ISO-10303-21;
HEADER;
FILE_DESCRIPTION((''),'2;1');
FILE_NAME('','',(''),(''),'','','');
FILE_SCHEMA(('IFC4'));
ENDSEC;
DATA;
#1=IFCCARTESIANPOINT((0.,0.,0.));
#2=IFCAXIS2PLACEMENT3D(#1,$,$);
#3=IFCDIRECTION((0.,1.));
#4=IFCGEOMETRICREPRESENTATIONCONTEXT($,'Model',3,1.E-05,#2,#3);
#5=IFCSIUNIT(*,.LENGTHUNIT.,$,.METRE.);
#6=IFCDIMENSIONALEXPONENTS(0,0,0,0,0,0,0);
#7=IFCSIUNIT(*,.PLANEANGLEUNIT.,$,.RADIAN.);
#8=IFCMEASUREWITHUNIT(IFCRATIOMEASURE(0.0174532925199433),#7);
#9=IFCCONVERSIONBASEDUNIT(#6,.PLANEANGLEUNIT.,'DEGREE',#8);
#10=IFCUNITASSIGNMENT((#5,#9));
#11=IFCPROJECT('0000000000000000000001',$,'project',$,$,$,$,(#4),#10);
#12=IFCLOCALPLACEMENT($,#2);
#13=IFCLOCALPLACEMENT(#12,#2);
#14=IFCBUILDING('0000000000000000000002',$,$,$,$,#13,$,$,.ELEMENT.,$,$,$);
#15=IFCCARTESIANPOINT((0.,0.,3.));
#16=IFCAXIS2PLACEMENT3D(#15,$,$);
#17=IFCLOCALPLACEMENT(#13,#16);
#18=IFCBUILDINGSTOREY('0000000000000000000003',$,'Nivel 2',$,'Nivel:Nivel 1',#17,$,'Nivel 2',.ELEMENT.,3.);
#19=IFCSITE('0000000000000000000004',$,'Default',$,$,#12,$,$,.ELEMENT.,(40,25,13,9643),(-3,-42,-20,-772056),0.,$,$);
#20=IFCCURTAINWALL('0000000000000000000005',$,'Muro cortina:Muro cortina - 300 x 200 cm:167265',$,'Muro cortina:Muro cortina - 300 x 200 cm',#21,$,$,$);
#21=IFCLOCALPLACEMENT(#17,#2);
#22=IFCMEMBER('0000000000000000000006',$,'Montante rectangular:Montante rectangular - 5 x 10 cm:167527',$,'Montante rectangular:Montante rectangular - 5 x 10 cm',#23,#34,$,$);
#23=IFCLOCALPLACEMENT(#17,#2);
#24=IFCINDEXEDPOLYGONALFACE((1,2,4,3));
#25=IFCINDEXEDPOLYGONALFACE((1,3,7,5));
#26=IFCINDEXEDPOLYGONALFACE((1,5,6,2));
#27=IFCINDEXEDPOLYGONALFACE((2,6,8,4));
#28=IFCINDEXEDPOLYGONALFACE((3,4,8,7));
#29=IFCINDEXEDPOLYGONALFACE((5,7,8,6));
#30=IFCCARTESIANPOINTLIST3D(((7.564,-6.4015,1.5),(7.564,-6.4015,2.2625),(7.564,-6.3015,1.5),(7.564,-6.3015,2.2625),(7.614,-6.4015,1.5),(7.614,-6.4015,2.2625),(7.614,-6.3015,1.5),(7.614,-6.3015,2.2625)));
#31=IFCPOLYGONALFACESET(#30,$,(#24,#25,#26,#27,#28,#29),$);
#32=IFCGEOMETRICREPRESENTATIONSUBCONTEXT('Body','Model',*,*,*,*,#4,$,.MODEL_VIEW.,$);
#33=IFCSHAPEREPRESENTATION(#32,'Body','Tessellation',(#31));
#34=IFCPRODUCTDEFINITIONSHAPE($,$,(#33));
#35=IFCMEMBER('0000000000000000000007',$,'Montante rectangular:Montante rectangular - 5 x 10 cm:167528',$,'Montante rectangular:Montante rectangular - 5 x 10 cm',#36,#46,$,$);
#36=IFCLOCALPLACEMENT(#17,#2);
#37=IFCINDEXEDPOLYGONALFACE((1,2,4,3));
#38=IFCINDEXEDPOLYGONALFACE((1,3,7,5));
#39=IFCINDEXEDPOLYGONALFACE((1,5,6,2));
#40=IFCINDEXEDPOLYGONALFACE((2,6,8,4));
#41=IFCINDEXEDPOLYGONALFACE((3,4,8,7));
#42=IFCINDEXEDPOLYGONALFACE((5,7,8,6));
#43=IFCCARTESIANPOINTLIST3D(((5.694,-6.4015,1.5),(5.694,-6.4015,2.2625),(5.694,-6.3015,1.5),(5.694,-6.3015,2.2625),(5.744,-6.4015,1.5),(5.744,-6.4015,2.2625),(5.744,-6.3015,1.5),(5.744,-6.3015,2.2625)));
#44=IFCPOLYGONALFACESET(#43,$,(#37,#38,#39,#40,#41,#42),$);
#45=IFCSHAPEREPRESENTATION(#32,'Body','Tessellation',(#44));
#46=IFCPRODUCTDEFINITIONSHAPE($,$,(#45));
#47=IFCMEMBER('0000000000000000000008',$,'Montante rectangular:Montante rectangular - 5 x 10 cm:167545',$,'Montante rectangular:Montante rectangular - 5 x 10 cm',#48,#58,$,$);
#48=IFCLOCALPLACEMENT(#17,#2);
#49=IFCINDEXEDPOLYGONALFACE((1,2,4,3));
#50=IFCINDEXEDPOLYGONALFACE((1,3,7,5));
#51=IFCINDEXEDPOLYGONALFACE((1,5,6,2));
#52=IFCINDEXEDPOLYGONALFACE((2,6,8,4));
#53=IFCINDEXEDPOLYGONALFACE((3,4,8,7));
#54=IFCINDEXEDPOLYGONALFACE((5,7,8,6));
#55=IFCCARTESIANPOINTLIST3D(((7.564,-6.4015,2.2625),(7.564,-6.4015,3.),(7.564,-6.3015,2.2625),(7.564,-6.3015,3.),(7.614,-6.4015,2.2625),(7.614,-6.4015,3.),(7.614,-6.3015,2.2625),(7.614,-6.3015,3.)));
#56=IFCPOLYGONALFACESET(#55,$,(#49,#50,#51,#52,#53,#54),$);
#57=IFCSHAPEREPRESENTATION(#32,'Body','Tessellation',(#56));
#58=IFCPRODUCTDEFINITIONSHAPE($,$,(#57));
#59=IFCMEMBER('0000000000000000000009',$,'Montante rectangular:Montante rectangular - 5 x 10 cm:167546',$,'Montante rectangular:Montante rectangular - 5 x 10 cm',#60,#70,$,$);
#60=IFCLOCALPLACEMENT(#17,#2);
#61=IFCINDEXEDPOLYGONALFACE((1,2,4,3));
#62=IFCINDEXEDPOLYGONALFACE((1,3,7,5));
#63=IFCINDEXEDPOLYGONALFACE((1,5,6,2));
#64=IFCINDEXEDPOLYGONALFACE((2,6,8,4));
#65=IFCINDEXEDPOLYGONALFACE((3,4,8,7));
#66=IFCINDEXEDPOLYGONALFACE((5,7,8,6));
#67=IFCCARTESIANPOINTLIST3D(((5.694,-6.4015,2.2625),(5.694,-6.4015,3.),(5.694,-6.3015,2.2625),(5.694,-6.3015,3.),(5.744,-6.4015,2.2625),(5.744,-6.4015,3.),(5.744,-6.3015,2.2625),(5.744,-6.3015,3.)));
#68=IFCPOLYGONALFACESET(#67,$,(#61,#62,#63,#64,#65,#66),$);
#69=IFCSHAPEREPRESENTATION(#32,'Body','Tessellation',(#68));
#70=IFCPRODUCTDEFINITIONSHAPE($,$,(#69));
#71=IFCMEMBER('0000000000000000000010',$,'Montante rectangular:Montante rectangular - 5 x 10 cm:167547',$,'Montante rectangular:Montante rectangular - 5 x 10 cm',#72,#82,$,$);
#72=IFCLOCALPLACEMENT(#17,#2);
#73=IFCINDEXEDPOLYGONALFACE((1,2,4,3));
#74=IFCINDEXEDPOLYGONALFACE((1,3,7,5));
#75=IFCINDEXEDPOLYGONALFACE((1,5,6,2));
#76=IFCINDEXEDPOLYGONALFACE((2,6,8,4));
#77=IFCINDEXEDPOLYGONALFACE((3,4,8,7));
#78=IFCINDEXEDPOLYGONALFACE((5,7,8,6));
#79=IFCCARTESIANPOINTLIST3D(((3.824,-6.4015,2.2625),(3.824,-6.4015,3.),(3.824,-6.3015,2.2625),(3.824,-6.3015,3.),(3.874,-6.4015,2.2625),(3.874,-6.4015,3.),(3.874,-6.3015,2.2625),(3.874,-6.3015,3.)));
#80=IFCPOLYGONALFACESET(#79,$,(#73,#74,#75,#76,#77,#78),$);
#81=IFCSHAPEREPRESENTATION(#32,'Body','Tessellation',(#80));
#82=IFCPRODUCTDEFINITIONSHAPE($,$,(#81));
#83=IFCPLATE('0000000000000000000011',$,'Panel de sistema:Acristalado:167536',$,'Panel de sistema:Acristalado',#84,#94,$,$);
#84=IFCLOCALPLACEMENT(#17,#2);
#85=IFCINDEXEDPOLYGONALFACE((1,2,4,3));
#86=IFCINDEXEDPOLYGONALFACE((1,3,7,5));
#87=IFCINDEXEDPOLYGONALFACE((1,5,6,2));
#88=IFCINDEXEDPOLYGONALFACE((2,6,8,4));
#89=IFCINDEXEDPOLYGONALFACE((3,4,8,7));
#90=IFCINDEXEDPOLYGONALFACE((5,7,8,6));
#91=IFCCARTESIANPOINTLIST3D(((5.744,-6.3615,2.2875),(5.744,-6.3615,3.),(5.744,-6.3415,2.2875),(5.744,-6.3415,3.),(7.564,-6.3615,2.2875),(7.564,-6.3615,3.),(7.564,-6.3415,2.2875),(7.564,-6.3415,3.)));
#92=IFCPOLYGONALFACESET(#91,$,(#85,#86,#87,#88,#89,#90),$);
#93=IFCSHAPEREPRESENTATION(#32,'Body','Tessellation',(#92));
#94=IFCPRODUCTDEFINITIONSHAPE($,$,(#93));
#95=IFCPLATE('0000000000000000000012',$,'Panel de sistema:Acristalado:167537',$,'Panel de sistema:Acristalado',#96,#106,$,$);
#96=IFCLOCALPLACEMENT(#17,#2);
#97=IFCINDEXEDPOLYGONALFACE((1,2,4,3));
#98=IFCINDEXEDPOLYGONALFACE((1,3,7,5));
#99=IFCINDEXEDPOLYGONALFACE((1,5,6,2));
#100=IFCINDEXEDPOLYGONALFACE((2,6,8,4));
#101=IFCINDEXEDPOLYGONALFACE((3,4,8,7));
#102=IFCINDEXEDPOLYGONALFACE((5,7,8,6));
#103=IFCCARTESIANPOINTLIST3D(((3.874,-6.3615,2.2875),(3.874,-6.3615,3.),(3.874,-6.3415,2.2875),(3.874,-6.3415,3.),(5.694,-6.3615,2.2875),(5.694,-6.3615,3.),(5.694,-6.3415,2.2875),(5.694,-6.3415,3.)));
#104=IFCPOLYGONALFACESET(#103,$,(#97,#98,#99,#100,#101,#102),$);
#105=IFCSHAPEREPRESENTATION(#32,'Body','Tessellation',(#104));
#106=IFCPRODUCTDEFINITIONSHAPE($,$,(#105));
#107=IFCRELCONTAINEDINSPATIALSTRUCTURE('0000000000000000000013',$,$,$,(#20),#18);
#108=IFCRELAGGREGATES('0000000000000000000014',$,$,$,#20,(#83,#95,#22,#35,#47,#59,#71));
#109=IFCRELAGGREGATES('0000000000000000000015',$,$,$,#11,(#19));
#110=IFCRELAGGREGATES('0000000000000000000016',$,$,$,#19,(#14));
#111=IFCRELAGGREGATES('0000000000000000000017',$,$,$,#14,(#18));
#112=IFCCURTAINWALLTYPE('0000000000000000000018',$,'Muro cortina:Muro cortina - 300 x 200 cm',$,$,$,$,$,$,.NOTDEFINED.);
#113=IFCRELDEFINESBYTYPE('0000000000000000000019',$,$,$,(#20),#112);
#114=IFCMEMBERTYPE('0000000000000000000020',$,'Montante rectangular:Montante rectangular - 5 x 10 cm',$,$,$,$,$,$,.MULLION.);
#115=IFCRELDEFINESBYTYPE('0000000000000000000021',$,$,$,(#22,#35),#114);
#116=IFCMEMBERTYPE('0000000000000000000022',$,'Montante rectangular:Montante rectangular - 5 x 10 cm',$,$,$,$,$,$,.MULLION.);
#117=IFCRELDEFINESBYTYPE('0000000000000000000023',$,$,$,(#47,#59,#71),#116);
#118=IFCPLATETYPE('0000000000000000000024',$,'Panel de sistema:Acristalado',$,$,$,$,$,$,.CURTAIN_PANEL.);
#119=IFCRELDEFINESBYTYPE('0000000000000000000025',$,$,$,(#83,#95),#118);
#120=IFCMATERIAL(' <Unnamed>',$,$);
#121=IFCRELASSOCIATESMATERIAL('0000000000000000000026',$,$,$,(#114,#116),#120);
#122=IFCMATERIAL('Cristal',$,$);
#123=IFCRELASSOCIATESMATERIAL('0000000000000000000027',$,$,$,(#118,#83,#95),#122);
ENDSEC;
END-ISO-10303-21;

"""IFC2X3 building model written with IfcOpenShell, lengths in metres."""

from ifc_helpers import new_model, entity, si_unit, converted_unit, direction, frame, origin, origin_2d_with_axis, place, context, subcontext, project, spatial, rectangle, extrude, source, transform, mapped, material, type_object, type_shapes, element, aggregate, save


model = new_model("IFC2X3")

# Units and contexts
model_context = context("Model", 3, precision=1e-05, world=origin(), true_north=direction((0.0, 1.0)))
body_context = subcontext(model_context, "Body", "Model", "MODEL_VIEW")
ifc_project = project(units=[si_unit("LENGTHUNIT", "METRE"), converted_unit("PLANEANGLEUNIT", "DEGREE", entity("IfcRatioMeasure", 0.0174532925199433), si_unit("PLANEANGLEUNIT", "RADIAN"), dimensions=[0, 0, 0, 0, 0, 0, 0])], contexts=[model_context])

# Site, building, storey
site_placement = place(None, origin())
site = spatial("IfcSite", under=ifc_project, at=site_placement, Name="Default", CompositionType="ELEMENT", RefLatitude=(40, 25, 13, 9643), RefLongitude=(-3, -42, -20, -772056), RefElevation=0.0)
building_placement = place(site_placement, origin())
building = spatial("IfcBuilding", under=site, at=building_placement, CompositionType="ELEMENT")
storey_placement = place(building_placement, frame((0.0, 0.0, 3.0)))
storey = spatial("IfcBuildingStorey", under=building, at=storey_placement, Name="Nivel 2", ObjectType="Nivel:Nivel 1", LongName="Nivel 2", CompositionType="ELEMENT", Elevation=3.0)

# Curtain wall, members, plates
curtain_wall_type = type_object("IfcCurtainWallType", Name="Muro cortina:Muro cortina - 300 x 200 cm", PredefinedType="NOTDEFINED")
curtain_wall_placement = place(storey_placement, frame((0.0, 0.0, -3.0)))
curtain_wall = element("IfcCurtainWall", 1, at=curtain_wall_placement, inside=storey, type_object=curtain_wall_type, Name="Muro cortina:Muro cortina - 300 x 200 cm:167265", ObjectType="Muro cortina:Muro cortina - 300 x 200 cm")
ifc_material_1 = material(Name=" <Unnamed>")
member_type_1 = type_object("IfcMemberType", Name="Montante rectangular:Montante rectangular - 5 x 10 cm", PredefinedType="MULLION", material=ifc_material_1)
shared_shape_1 = source(origin(), body_context, "Body", "SweptSolid", [
    extrude(rectangle(XDim=0.1, YDim=0.05, at=origin_2d_with_axis()), frame((0.0, 0.0, -0.7625), z_axis=(0.0, 0.0, 1.0), x_axis=(0.0, -1.0, 0.0)), (0.0, 0.0, 1.0), 0.7625),
])
type_shapes(member_type_1, [shared_shape_1])
member_1_placement = place(storey_placement, frame((7.589, -6.3515, 1.5), z_axis=(0.0, 0.0, -1.0), x_axis=(-1.0, 0.0, 0.0)))
member_1 = element("IfcMember", 2, at=member_1_placement, type_object=member_type_1, Name="Montante rectangular:Montante rectangular - 5 x 10 cm:167527", ObjectType="Montante rectangular:Montante rectangular - 5 x 10 cm", context=body_context, shape_type="MappedRepresentation", body=[
    mapped(shared_shape_1, transform((0.0, 0.0, 0.0), scale=1.0)),
])
member_2_placement = place(storey_placement, frame((5.719, -6.3515, 1.5), z_axis=(0.0, 0.0, -1.0), x_axis=(-1.0, 0.0, 0.0)))
member_2 = element("IfcMember", 3, at=member_2_placement, type_object=member_type_1, Name="Montante rectangular:Montante rectangular - 5 x 10 cm:167528", ObjectType="Montante rectangular:Montante rectangular - 5 x 10 cm", context=body_context, shape_type="MappedRepresentation", body=[
    mapped(shared_shape_1, transform((0.0, 0.0, 0.0), scale=1.0)),
])
member_type_2 = type_object("IfcMemberType", Name="Montante rectangular:Montante rectangular - 5 x 10 cm", PredefinedType="MULLION", material=ifc_material_1)
shared_shape_2 = source(origin(), body_context, "Body", "SweptSolid", [
    extrude(rectangle(XDim=0.1, YDim=0.05, at=origin_2d_with_axis()), frame((0.0, 0.0, -0.7375), z_axis=(0.0, 0.0, 1.0), x_axis=(0.0, -1.0, 0.0)), (0.0, 0.0, 1.0), 0.7375),
])
type_shapes(member_type_2, [shared_shape_2])
member_3_placement = place(storey_placement, frame((7.589, -6.3515, 2.2625), z_axis=(0.0, 0.0, -1.0), x_axis=(-1.0, 0.0, 0.0)))
member_3 = element("IfcMember", 4, at=member_3_placement, type_object=member_type_2, Name="Montante rectangular:Montante rectangular - 5 x 10 cm:167545", ObjectType="Montante rectangular:Montante rectangular - 5 x 10 cm", context=body_context, shape_type="MappedRepresentation", body=[
    mapped(shared_shape_2, transform((0.0, 0.0, 0.0), scale=1.0)),
])
member_4_placement = place(storey_placement, frame((5.719, -6.3515, 2.2625), z_axis=(0.0, 0.0, -1.0), x_axis=(-1.0, 0.0, 0.0)))
member_4 = element("IfcMember", 5, at=member_4_placement, type_object=member_type_2, Name="Montante rectangular:Montante rectangular - 5 x 10 cm:167546", ObjectType="Montante rectangular:Montante rectangular - 5 x 10 cm", context=body_context, shape_type="MappedRepresentation", body=[
    mapped(shared_shape_2, transform((0.0, 0.0, 0.0), scale=1.0)),
])
member_5_placement = place(storey_placement, frame((3.849, -6.3515, 2.2625), z_axis=(0.0, 0.0, -1.0), x_axis=(-1.0, 0.0, 0.0)))
member_5 = element("IfcMember", 6, at=member_5_placement, type_object=member_type_2, Name="Montante rectangular:Montante rectangular - 5 x 10 cm:167547", ObjectType="Montante rectangular:Montante rectangular - 5 x 10 cm", context=body_context, shape_type="MappedRepresentation", body=[
    mapped(shared_shape_2, transform((0.0, 0.0, 0.0), scale=1.0)),
])
ifc_material_2 = material(Name="Cristal")
plate_type = type_object("IfcPlateType", Name="Panel de sistema:Acristalado", PredefinedType="CURTAIN_PANEL", material=ifc_material_2)
shared_shape_3 = source(origin(), body_context, "Body", "SweptSolid", [
    extrude(rectangle(XDim=0.02, YDim=1.82, at=origin_2d_with_axis()), frame((0.0, 0.0, 0.0), z_axis=(0.0, 0.0, 1.0), x_axis=(0.0, 1.0, 0.0)), (0.0, 0.0, 1.0), 0.7125),
])
type_shapes(plate_type, [shared_shape_3])
plate_1_placement = place(curtain_wall_placement, frame((6.654, -6.3515, 5.2875), z_axis=(0.0, 0.0, 1.0), x_axis=(-1.0, 0.0, 0.0)))
plate_1 = element("IfcPlate", 7, at=plate_1_placement, type_object=plate_type, material=ifc_material_2, Name="Panel de sistema:Acristalado:167536", ObjectType="Panel de sistema:Acristalado", context=body_context, shape_type="MappedRepresentation", body=[
    mapped(shared_shape_3, transform((0.0, 0.0, 0.0), scale=1.0)),
])
plate_2_placement = place(curtain_wall_placement, frame((4.784, -6.3515, 5.2875), z_axis=(0.0, 0.0, 1.0), x_axis=(-1.0, 0.0, 0.0)))
plate_2 = element("IfcPlate", 8, at=plate_2_placement, type_object=plate_type, material=ifc_material_2, Name="Panel de sistema:Acristalado:167537", ObjectType="Panel de sistema:Acristalado", context=body_context, shape_type="MappedRepresentation", body=[
    mapped(shared_shape_3, transform((0.0, 0.0, 0.0), scale=1.0)),
])
aggregate(curtain_wall, [plate_1, plate_2, member_1, member_2, member_3, member_4, member_5])

save(model, "model.ifc")
